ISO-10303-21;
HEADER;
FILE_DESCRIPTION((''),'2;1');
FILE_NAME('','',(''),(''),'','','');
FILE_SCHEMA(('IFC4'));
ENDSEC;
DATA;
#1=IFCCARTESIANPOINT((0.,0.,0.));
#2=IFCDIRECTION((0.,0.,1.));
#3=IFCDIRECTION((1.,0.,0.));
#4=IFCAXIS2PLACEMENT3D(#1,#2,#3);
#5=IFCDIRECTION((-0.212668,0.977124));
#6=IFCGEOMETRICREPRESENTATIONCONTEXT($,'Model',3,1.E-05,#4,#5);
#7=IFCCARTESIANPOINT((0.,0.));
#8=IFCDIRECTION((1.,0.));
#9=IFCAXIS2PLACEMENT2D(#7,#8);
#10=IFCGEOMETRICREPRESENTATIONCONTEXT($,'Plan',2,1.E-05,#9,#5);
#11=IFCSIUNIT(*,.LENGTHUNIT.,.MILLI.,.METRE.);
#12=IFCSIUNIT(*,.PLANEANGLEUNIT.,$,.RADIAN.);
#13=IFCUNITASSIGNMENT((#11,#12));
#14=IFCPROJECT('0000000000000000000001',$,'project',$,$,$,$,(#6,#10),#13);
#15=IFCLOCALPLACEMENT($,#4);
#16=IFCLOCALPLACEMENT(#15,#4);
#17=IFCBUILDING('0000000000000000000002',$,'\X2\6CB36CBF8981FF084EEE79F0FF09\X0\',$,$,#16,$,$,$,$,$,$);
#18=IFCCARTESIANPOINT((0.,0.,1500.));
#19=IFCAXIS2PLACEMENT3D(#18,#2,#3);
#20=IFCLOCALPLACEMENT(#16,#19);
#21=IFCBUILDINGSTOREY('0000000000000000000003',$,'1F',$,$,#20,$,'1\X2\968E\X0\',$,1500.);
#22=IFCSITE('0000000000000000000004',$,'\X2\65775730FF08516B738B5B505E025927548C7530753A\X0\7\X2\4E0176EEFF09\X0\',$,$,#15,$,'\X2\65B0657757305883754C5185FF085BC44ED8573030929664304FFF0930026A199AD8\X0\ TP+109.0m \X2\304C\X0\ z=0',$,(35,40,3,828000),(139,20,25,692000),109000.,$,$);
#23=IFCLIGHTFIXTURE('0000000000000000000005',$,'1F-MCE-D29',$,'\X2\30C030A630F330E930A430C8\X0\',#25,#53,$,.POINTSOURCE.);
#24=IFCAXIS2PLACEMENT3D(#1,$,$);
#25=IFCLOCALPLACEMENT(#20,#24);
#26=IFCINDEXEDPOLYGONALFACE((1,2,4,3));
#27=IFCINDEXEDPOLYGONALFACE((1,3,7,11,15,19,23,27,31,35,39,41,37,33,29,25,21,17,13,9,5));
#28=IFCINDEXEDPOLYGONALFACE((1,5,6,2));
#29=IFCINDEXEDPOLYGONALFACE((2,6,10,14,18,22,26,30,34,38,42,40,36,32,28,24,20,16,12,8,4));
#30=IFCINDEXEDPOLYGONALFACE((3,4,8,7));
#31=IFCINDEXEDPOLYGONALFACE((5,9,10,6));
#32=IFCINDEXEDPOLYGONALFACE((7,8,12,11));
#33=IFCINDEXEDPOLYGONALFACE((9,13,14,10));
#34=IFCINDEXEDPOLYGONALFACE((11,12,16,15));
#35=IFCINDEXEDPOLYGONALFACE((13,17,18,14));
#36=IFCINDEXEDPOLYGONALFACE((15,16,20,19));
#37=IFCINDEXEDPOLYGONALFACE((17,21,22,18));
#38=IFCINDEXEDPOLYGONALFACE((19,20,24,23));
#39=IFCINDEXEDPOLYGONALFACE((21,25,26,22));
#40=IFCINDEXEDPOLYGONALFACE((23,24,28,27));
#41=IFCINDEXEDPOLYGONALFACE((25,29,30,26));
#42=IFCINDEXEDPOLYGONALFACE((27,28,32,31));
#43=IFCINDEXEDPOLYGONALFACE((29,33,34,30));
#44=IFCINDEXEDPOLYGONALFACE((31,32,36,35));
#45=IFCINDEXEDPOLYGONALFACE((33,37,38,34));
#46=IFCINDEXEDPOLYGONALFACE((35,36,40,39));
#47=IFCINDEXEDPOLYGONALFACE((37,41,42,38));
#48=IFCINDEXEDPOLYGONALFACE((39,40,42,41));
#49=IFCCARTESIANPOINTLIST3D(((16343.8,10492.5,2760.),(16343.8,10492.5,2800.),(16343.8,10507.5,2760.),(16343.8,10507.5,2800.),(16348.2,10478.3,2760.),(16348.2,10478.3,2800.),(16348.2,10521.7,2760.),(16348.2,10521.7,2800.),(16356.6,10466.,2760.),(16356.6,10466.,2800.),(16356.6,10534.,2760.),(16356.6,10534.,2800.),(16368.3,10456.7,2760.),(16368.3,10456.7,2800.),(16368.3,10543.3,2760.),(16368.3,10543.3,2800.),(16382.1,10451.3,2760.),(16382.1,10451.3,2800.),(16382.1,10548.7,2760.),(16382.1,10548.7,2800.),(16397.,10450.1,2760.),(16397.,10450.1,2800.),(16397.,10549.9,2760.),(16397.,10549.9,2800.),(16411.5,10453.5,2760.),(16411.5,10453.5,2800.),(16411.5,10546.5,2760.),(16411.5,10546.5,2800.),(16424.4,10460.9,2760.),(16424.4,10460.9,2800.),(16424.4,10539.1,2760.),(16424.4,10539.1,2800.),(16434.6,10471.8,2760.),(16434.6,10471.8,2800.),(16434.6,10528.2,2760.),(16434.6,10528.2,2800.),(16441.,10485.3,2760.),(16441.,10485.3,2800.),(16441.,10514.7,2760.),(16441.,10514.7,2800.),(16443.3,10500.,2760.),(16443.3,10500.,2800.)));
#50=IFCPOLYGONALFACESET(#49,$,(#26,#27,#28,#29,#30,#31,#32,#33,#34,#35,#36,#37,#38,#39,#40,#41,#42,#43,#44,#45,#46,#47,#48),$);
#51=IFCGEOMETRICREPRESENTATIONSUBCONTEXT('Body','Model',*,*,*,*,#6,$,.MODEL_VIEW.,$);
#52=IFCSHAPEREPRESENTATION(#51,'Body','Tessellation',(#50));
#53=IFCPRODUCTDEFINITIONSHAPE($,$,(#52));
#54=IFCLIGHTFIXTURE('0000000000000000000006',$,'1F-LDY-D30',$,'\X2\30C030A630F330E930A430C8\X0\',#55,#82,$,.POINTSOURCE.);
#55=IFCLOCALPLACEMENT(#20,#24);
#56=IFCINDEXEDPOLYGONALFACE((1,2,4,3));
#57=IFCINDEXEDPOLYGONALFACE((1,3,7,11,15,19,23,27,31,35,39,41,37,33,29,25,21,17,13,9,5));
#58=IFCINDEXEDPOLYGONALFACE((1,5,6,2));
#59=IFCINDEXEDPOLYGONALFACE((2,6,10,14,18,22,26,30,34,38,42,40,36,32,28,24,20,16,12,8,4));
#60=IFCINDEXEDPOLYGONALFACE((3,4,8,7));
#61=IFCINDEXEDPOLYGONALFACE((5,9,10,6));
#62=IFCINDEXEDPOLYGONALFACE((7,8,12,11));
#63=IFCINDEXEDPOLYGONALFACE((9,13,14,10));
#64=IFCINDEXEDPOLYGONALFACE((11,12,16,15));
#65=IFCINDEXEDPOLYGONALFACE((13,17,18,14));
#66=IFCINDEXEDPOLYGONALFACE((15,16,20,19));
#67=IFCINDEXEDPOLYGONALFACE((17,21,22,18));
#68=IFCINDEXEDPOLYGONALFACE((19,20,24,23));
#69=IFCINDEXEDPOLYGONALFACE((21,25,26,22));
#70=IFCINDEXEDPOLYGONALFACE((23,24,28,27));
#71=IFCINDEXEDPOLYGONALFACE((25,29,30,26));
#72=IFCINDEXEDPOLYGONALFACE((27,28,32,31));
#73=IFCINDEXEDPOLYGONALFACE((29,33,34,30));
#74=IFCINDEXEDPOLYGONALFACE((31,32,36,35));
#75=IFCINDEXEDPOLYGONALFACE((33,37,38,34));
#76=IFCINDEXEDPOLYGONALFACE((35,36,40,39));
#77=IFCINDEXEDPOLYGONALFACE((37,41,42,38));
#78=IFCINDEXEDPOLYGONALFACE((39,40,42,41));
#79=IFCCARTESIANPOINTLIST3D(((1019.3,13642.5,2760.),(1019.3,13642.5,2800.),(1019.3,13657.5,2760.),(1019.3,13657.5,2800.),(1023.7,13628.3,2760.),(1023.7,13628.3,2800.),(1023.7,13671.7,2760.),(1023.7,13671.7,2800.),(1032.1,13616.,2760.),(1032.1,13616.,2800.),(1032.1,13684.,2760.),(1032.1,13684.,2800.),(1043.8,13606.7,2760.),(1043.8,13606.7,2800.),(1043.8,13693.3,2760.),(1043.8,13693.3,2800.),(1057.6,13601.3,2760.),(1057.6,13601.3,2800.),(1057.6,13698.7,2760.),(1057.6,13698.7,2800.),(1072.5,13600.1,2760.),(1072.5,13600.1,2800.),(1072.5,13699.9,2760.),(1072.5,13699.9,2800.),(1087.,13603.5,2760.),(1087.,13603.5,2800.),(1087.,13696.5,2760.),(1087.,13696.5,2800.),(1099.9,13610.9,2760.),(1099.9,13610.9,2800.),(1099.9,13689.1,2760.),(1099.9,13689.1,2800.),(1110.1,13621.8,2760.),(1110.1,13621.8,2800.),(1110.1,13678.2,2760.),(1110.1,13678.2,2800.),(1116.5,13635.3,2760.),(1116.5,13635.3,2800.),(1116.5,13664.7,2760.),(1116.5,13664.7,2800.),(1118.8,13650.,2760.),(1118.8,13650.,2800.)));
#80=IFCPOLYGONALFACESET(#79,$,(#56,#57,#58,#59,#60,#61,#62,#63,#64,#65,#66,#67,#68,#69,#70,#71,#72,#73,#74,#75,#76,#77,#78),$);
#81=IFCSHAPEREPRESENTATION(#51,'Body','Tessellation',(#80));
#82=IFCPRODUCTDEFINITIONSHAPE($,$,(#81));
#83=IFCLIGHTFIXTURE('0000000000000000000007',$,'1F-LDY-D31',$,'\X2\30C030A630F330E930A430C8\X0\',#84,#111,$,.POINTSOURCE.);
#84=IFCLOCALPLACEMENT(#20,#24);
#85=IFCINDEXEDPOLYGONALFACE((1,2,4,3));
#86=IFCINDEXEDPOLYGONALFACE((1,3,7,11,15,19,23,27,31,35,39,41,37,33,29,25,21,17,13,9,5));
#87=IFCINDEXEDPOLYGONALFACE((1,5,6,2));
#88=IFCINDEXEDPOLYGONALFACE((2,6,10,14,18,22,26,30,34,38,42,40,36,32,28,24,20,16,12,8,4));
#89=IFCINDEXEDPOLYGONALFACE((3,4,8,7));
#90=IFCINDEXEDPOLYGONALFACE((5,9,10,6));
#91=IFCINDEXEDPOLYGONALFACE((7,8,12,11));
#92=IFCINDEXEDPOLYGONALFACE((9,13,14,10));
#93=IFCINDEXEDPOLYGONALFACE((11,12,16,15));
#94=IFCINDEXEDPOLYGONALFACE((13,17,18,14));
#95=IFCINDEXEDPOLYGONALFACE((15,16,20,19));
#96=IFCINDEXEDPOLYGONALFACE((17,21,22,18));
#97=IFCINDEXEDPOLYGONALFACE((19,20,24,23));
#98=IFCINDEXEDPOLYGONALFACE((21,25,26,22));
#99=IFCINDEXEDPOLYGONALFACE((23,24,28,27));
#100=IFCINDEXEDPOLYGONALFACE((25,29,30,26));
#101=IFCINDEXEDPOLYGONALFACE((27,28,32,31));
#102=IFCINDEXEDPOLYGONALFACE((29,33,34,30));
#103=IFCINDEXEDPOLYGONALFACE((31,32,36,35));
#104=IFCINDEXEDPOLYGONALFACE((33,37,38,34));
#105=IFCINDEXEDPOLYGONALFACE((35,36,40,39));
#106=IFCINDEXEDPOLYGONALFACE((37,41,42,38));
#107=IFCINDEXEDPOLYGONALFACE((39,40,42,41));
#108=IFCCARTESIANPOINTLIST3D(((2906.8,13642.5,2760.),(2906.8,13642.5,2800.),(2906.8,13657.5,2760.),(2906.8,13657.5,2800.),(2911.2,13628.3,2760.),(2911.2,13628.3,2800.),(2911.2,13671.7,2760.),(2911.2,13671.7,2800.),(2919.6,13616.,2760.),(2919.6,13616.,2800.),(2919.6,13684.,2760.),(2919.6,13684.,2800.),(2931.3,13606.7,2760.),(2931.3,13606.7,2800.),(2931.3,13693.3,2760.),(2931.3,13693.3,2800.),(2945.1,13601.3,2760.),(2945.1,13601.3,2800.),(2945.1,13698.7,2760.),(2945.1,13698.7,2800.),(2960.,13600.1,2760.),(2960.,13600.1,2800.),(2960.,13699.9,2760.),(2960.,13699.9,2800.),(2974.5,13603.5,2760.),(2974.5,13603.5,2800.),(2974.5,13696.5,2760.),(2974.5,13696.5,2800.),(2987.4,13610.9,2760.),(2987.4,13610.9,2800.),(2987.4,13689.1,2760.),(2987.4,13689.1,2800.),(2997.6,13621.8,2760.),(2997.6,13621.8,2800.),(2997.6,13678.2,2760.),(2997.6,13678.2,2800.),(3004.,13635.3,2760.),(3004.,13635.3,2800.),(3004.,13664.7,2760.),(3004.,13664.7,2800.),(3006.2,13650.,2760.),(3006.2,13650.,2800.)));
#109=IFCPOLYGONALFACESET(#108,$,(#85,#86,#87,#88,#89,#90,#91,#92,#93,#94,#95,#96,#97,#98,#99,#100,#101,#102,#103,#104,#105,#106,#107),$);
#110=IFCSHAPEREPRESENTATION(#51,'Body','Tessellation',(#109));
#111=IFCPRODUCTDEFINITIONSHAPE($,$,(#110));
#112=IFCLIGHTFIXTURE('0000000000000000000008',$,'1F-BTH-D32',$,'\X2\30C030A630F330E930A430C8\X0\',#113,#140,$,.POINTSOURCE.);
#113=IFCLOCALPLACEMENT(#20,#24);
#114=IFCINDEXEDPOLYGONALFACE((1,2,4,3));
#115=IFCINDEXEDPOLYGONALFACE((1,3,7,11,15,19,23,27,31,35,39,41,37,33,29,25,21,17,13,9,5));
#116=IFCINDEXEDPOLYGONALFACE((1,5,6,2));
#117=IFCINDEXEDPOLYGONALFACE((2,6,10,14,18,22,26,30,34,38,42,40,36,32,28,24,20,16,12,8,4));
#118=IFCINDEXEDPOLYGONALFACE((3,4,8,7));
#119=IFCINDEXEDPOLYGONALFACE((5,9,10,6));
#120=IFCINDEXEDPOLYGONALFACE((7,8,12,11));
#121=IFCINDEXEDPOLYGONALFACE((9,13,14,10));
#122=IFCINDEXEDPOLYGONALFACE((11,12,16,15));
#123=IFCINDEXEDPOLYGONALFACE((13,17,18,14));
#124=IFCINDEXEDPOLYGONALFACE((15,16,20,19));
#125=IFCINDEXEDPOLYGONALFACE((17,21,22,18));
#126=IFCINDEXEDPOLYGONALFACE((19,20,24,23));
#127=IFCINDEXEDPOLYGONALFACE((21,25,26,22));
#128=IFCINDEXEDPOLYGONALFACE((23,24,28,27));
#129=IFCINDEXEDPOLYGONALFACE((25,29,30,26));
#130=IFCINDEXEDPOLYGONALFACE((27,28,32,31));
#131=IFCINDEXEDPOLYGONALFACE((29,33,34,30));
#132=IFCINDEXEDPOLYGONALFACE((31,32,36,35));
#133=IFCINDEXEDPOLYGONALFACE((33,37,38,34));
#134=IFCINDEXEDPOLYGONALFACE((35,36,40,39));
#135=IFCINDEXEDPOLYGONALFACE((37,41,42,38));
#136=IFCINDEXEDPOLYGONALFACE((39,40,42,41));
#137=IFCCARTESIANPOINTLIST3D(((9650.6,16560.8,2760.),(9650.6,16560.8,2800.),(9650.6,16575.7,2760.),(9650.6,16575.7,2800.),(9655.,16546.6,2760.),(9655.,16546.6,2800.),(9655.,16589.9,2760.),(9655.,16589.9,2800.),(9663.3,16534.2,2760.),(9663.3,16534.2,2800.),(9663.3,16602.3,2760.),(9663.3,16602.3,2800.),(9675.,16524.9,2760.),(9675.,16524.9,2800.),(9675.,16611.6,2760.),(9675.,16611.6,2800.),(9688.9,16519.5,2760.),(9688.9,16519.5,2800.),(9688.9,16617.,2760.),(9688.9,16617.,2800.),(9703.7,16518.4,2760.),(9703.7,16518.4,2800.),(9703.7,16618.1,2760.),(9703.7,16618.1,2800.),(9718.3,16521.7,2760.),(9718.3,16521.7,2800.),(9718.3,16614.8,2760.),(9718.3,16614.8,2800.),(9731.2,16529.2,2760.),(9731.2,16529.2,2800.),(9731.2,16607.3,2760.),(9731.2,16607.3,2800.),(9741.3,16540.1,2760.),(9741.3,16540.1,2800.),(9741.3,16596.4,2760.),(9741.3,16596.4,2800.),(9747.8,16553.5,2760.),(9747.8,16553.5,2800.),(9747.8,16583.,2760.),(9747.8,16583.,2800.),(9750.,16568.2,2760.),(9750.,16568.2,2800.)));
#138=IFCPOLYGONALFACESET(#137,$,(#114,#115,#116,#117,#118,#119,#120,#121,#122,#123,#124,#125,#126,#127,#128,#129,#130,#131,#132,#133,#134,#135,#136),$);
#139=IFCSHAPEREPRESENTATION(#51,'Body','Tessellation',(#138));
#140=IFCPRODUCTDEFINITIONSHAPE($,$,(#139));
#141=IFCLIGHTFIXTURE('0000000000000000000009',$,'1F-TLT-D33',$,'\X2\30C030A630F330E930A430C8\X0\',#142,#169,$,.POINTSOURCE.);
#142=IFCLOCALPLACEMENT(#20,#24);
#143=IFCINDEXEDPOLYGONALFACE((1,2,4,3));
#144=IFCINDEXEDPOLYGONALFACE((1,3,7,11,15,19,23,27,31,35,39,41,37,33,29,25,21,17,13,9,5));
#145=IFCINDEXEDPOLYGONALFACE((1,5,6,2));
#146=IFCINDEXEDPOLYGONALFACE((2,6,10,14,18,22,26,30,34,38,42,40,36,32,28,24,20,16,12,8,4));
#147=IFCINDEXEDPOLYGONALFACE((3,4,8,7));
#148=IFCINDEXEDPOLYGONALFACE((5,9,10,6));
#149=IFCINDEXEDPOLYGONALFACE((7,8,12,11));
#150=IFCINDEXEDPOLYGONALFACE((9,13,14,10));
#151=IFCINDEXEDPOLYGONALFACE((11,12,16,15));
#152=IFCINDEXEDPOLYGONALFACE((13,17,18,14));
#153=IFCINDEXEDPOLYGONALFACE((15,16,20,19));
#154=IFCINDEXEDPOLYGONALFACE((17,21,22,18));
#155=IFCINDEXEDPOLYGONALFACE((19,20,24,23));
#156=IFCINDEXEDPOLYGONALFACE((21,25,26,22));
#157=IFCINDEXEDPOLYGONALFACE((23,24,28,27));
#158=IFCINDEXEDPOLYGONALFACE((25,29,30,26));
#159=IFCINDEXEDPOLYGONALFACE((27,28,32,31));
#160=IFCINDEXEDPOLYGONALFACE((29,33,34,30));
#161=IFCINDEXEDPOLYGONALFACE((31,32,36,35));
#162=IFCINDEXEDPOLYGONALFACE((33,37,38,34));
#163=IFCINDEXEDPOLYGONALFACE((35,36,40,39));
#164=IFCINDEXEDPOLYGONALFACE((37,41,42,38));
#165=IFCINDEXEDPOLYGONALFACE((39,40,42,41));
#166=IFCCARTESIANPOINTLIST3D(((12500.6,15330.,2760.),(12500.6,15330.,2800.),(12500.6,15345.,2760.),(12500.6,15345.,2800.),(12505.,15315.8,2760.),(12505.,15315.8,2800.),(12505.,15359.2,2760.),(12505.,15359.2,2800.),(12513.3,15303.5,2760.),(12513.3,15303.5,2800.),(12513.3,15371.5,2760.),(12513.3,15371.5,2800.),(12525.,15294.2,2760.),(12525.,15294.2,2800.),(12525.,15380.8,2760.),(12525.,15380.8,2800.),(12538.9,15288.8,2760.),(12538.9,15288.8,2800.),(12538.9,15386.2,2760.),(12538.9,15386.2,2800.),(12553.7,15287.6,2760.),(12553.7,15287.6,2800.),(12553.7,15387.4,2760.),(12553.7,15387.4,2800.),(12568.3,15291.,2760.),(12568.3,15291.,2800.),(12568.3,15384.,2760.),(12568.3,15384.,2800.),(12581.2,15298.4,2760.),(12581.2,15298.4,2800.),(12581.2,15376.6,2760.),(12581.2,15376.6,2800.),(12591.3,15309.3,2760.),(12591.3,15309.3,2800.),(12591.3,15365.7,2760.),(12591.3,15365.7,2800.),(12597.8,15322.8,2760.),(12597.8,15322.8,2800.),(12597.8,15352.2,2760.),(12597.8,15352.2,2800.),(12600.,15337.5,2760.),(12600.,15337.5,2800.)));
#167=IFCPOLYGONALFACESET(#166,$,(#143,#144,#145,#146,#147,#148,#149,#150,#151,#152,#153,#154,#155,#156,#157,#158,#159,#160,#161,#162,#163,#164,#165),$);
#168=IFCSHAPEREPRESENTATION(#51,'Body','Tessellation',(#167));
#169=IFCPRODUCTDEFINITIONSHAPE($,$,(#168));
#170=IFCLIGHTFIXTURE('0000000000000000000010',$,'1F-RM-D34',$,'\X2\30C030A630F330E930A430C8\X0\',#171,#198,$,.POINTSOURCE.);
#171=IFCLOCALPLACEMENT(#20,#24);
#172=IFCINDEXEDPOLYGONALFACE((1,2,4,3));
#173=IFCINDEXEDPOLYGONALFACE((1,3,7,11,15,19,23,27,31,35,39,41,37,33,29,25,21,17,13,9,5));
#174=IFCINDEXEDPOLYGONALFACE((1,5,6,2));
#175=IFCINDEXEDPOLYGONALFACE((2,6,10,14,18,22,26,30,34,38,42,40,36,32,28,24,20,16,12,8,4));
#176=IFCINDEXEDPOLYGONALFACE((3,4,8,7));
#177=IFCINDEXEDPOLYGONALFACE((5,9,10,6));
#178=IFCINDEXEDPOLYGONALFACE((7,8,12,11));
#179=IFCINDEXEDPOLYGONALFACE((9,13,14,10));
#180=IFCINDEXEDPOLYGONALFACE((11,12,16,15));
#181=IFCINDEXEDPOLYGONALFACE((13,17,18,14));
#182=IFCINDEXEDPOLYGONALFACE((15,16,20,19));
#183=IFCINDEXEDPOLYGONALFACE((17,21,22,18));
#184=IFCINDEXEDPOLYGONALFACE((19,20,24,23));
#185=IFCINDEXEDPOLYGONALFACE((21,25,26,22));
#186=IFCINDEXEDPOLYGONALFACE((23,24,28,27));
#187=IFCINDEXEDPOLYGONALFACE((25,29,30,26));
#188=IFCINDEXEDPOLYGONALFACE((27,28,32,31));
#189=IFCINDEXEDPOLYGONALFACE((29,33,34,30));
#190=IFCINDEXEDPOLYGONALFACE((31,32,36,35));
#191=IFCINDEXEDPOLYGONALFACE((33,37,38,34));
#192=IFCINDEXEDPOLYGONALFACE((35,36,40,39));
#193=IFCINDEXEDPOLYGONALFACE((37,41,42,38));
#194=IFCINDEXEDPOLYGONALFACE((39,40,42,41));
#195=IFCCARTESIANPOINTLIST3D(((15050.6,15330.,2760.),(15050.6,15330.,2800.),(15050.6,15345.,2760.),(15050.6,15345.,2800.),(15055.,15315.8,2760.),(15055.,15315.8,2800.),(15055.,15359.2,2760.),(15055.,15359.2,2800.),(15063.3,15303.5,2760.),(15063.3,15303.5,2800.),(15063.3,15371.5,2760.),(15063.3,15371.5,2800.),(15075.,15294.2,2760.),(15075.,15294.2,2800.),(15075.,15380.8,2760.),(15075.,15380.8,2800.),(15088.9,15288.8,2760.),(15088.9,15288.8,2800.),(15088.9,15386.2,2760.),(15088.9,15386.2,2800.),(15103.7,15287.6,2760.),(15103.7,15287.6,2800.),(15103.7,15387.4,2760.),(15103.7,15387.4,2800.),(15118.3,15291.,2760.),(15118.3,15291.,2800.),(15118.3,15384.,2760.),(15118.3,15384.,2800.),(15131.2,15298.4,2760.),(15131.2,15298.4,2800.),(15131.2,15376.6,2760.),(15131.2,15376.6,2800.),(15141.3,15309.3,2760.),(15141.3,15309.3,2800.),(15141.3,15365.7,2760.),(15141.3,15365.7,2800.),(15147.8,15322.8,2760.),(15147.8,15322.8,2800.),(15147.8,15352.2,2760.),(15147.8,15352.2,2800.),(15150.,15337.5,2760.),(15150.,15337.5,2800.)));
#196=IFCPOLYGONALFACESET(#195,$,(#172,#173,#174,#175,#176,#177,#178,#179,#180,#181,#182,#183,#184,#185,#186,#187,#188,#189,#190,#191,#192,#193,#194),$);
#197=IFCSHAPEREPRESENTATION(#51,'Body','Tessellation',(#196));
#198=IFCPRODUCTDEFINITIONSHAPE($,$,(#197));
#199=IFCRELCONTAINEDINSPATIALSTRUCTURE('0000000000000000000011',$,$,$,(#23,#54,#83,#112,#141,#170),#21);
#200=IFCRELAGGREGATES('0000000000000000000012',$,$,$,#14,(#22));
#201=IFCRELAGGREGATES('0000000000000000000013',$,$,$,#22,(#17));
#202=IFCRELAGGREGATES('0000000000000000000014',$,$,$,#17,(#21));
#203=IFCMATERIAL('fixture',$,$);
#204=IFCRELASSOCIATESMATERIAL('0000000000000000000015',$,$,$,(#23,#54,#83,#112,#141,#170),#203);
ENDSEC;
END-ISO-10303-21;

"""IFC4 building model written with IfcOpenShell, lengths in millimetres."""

from ifc_helpers import new_model, si_unit, direction, frame, frame_2d, origin_with_axes, origin_2d_with_axis, place, context, subcontext, project, spatial, circle, extrude, material, element, save


model = new_model("IFC4")

# Units and contexts
model_context = context("Model", 3, precision=1e-05, world=origin_with_axes(), true_north=direction((-0.212668, 0.977124)))
plan_context = context("Plan", 2, precision=1e-05, world=origin_2d_with_axis(), true_north=direction((-0.212668, 0.977124)))
body_context = subcontext(model_context, "Body", "Model", "MODEL_VIEW")
ifc_project = project(units=[si_unit("LENGTHUNIT", "METRE", prefix="MILLI"), si_unit("PLANEANGLEUNIT", "RADIAN")], contexts=[model_context, plan_context])

# Site, building, storey
site_placement = place(None, origin_with_axes())
site = spatial("IfcSite", under=ifc_project, at=site_placement, Name="敷地（八王子市大和田町7丁目）", LongName="新敷地境界内（寄付地を除く）。標高 TP+109.0m が z=0", RefLatitude=(35, 40, 3, 828000), RefLongitude=(139, 20, 25, 692000), RefElevation=109000.0)
building_placement = place(site_placement, origin_with_axes())
building = spatial("IfcBuilding", under=site, at=building_placement, Name="河沿要（仮称）")
storey_placement = place(building_placement, frame((0.0, 0.0, 1500.0), z_axis=(0.0, 0.0, 1.0), x_axis=(1.0, 0.0, 0.0)))
storey = spatial("IfcBuildingStorey", under=building, at=storey_placement, Name="1F", LongName="1階", Elevation=1500.0)

# Light fixtures
ifc_material = material(Name="fixture")
light_fixture_1_placement = place(storey_placement, origin_with_axes())
element("IfcLightFixture", 1, at=light_fixture_1_placement, inside=storey, material=ifc_material, Name="1F-MCE-D29", ObjectType="ダウンライト", PredefinedType="POINTSOURCE", context=body_context, shape_type="SweptSolid", body=[
    extrude(circle(Radius=50.0, at=frame_2d((16393.2, 10500.0))), frame((0.0, 0.0, 2760.0)), (0.0, 0.0, 1.0), 40.0),
])
light_fixture_2_placement = place(storey_placement, origin_with_axes())
element("IfcLightFixture", 2, at=light_fixture_2_placement, inside=storey, material=ifc_material, Name="1F-LDY-D30", ObjectType="ダウンライト", PredefinedType="POINTSOURCE", context=body_context, shape_type="SweptSolid", body=[
    extrude(circle(Radius=50.0, at=frame_2d((1068.8, 13650.0))), frame((0.0, 0.0, 2760.0)), (0.0, 0.0, 1.0), 40.0),
])
light_fixture_3_placement = place(storey_placement, origin_with_axes())
element("IfcLightFixture", 3, at=light_fixture_3_placement, inside=storey, material=ifc_material, Name="1F-LDY-D31", ObjectType="ダウンライト", PredefinedType="POINTSOURCE", context=body_context, shape_type="SweptSolid", body=[
    extrude(circle(Radius=50.0, at=frame_2d((2956.2, 13650.0))), frame((0.0, 0.0, 2760.0)), (0.0, 0.0, 1.0), 40.0),
])
light_fixture_4_placement = place(storey_placement, origin_with_axes())
element("IfcLightFixture", 4, at=light_fixture_4_placement, inside=storey, material=ifc_material, Name="1F-BTH-D32", ObjectType="ダウンライト", PredefinedType="POINTSOURCE", context=body_context, shape_type="SweptSolid", body=[
    extrude(circle(Radius=50.0, at=frame_2d((9700.0, 16568.2))), frame((0.0, 0.0, 2760.0)), (0.0, 0.0, 1.0), 40.0),
])
light_fixture_5_placement = place(storey_placement, origin_with_axes())
element("IfcLightFixture", 5, at=light_fixture_5_placement, inside=storey, material=ifc_material, Name="1F-TLT-D33", ObjectType="ダウンライト", PredefinedType="POINTSOURCE", context=body_context, shape_type="SweptSolid", body=[
    extrude(circle(Radius=50.0, at=frame_2d((12550.0, 15337.5))), frame((0.0, 0.0, 2760.0)), (0.0, 0.0, 1.0), 40.0),
])
light_fixture_6_placement = place(storey_placement, origin_with_axes())
element("IfcLightFixture", 6, at=light_fixture_6_placement, inside=storey, material=ifc_material, Name="1F-RM-D34", ObjectType="ダウンライト", PredefinedType="POINTSOURCE", context=body_context, shape_type="SweptSolid", body=[
    extrude(circle(Radius=50.0, at=frame_2d((15100.0, 15337.5))), frame((0.0, 0.0, 2760.0)), (0.0, 0.0, 1.0), 40.0),
])

save(model, "model.ifc")
